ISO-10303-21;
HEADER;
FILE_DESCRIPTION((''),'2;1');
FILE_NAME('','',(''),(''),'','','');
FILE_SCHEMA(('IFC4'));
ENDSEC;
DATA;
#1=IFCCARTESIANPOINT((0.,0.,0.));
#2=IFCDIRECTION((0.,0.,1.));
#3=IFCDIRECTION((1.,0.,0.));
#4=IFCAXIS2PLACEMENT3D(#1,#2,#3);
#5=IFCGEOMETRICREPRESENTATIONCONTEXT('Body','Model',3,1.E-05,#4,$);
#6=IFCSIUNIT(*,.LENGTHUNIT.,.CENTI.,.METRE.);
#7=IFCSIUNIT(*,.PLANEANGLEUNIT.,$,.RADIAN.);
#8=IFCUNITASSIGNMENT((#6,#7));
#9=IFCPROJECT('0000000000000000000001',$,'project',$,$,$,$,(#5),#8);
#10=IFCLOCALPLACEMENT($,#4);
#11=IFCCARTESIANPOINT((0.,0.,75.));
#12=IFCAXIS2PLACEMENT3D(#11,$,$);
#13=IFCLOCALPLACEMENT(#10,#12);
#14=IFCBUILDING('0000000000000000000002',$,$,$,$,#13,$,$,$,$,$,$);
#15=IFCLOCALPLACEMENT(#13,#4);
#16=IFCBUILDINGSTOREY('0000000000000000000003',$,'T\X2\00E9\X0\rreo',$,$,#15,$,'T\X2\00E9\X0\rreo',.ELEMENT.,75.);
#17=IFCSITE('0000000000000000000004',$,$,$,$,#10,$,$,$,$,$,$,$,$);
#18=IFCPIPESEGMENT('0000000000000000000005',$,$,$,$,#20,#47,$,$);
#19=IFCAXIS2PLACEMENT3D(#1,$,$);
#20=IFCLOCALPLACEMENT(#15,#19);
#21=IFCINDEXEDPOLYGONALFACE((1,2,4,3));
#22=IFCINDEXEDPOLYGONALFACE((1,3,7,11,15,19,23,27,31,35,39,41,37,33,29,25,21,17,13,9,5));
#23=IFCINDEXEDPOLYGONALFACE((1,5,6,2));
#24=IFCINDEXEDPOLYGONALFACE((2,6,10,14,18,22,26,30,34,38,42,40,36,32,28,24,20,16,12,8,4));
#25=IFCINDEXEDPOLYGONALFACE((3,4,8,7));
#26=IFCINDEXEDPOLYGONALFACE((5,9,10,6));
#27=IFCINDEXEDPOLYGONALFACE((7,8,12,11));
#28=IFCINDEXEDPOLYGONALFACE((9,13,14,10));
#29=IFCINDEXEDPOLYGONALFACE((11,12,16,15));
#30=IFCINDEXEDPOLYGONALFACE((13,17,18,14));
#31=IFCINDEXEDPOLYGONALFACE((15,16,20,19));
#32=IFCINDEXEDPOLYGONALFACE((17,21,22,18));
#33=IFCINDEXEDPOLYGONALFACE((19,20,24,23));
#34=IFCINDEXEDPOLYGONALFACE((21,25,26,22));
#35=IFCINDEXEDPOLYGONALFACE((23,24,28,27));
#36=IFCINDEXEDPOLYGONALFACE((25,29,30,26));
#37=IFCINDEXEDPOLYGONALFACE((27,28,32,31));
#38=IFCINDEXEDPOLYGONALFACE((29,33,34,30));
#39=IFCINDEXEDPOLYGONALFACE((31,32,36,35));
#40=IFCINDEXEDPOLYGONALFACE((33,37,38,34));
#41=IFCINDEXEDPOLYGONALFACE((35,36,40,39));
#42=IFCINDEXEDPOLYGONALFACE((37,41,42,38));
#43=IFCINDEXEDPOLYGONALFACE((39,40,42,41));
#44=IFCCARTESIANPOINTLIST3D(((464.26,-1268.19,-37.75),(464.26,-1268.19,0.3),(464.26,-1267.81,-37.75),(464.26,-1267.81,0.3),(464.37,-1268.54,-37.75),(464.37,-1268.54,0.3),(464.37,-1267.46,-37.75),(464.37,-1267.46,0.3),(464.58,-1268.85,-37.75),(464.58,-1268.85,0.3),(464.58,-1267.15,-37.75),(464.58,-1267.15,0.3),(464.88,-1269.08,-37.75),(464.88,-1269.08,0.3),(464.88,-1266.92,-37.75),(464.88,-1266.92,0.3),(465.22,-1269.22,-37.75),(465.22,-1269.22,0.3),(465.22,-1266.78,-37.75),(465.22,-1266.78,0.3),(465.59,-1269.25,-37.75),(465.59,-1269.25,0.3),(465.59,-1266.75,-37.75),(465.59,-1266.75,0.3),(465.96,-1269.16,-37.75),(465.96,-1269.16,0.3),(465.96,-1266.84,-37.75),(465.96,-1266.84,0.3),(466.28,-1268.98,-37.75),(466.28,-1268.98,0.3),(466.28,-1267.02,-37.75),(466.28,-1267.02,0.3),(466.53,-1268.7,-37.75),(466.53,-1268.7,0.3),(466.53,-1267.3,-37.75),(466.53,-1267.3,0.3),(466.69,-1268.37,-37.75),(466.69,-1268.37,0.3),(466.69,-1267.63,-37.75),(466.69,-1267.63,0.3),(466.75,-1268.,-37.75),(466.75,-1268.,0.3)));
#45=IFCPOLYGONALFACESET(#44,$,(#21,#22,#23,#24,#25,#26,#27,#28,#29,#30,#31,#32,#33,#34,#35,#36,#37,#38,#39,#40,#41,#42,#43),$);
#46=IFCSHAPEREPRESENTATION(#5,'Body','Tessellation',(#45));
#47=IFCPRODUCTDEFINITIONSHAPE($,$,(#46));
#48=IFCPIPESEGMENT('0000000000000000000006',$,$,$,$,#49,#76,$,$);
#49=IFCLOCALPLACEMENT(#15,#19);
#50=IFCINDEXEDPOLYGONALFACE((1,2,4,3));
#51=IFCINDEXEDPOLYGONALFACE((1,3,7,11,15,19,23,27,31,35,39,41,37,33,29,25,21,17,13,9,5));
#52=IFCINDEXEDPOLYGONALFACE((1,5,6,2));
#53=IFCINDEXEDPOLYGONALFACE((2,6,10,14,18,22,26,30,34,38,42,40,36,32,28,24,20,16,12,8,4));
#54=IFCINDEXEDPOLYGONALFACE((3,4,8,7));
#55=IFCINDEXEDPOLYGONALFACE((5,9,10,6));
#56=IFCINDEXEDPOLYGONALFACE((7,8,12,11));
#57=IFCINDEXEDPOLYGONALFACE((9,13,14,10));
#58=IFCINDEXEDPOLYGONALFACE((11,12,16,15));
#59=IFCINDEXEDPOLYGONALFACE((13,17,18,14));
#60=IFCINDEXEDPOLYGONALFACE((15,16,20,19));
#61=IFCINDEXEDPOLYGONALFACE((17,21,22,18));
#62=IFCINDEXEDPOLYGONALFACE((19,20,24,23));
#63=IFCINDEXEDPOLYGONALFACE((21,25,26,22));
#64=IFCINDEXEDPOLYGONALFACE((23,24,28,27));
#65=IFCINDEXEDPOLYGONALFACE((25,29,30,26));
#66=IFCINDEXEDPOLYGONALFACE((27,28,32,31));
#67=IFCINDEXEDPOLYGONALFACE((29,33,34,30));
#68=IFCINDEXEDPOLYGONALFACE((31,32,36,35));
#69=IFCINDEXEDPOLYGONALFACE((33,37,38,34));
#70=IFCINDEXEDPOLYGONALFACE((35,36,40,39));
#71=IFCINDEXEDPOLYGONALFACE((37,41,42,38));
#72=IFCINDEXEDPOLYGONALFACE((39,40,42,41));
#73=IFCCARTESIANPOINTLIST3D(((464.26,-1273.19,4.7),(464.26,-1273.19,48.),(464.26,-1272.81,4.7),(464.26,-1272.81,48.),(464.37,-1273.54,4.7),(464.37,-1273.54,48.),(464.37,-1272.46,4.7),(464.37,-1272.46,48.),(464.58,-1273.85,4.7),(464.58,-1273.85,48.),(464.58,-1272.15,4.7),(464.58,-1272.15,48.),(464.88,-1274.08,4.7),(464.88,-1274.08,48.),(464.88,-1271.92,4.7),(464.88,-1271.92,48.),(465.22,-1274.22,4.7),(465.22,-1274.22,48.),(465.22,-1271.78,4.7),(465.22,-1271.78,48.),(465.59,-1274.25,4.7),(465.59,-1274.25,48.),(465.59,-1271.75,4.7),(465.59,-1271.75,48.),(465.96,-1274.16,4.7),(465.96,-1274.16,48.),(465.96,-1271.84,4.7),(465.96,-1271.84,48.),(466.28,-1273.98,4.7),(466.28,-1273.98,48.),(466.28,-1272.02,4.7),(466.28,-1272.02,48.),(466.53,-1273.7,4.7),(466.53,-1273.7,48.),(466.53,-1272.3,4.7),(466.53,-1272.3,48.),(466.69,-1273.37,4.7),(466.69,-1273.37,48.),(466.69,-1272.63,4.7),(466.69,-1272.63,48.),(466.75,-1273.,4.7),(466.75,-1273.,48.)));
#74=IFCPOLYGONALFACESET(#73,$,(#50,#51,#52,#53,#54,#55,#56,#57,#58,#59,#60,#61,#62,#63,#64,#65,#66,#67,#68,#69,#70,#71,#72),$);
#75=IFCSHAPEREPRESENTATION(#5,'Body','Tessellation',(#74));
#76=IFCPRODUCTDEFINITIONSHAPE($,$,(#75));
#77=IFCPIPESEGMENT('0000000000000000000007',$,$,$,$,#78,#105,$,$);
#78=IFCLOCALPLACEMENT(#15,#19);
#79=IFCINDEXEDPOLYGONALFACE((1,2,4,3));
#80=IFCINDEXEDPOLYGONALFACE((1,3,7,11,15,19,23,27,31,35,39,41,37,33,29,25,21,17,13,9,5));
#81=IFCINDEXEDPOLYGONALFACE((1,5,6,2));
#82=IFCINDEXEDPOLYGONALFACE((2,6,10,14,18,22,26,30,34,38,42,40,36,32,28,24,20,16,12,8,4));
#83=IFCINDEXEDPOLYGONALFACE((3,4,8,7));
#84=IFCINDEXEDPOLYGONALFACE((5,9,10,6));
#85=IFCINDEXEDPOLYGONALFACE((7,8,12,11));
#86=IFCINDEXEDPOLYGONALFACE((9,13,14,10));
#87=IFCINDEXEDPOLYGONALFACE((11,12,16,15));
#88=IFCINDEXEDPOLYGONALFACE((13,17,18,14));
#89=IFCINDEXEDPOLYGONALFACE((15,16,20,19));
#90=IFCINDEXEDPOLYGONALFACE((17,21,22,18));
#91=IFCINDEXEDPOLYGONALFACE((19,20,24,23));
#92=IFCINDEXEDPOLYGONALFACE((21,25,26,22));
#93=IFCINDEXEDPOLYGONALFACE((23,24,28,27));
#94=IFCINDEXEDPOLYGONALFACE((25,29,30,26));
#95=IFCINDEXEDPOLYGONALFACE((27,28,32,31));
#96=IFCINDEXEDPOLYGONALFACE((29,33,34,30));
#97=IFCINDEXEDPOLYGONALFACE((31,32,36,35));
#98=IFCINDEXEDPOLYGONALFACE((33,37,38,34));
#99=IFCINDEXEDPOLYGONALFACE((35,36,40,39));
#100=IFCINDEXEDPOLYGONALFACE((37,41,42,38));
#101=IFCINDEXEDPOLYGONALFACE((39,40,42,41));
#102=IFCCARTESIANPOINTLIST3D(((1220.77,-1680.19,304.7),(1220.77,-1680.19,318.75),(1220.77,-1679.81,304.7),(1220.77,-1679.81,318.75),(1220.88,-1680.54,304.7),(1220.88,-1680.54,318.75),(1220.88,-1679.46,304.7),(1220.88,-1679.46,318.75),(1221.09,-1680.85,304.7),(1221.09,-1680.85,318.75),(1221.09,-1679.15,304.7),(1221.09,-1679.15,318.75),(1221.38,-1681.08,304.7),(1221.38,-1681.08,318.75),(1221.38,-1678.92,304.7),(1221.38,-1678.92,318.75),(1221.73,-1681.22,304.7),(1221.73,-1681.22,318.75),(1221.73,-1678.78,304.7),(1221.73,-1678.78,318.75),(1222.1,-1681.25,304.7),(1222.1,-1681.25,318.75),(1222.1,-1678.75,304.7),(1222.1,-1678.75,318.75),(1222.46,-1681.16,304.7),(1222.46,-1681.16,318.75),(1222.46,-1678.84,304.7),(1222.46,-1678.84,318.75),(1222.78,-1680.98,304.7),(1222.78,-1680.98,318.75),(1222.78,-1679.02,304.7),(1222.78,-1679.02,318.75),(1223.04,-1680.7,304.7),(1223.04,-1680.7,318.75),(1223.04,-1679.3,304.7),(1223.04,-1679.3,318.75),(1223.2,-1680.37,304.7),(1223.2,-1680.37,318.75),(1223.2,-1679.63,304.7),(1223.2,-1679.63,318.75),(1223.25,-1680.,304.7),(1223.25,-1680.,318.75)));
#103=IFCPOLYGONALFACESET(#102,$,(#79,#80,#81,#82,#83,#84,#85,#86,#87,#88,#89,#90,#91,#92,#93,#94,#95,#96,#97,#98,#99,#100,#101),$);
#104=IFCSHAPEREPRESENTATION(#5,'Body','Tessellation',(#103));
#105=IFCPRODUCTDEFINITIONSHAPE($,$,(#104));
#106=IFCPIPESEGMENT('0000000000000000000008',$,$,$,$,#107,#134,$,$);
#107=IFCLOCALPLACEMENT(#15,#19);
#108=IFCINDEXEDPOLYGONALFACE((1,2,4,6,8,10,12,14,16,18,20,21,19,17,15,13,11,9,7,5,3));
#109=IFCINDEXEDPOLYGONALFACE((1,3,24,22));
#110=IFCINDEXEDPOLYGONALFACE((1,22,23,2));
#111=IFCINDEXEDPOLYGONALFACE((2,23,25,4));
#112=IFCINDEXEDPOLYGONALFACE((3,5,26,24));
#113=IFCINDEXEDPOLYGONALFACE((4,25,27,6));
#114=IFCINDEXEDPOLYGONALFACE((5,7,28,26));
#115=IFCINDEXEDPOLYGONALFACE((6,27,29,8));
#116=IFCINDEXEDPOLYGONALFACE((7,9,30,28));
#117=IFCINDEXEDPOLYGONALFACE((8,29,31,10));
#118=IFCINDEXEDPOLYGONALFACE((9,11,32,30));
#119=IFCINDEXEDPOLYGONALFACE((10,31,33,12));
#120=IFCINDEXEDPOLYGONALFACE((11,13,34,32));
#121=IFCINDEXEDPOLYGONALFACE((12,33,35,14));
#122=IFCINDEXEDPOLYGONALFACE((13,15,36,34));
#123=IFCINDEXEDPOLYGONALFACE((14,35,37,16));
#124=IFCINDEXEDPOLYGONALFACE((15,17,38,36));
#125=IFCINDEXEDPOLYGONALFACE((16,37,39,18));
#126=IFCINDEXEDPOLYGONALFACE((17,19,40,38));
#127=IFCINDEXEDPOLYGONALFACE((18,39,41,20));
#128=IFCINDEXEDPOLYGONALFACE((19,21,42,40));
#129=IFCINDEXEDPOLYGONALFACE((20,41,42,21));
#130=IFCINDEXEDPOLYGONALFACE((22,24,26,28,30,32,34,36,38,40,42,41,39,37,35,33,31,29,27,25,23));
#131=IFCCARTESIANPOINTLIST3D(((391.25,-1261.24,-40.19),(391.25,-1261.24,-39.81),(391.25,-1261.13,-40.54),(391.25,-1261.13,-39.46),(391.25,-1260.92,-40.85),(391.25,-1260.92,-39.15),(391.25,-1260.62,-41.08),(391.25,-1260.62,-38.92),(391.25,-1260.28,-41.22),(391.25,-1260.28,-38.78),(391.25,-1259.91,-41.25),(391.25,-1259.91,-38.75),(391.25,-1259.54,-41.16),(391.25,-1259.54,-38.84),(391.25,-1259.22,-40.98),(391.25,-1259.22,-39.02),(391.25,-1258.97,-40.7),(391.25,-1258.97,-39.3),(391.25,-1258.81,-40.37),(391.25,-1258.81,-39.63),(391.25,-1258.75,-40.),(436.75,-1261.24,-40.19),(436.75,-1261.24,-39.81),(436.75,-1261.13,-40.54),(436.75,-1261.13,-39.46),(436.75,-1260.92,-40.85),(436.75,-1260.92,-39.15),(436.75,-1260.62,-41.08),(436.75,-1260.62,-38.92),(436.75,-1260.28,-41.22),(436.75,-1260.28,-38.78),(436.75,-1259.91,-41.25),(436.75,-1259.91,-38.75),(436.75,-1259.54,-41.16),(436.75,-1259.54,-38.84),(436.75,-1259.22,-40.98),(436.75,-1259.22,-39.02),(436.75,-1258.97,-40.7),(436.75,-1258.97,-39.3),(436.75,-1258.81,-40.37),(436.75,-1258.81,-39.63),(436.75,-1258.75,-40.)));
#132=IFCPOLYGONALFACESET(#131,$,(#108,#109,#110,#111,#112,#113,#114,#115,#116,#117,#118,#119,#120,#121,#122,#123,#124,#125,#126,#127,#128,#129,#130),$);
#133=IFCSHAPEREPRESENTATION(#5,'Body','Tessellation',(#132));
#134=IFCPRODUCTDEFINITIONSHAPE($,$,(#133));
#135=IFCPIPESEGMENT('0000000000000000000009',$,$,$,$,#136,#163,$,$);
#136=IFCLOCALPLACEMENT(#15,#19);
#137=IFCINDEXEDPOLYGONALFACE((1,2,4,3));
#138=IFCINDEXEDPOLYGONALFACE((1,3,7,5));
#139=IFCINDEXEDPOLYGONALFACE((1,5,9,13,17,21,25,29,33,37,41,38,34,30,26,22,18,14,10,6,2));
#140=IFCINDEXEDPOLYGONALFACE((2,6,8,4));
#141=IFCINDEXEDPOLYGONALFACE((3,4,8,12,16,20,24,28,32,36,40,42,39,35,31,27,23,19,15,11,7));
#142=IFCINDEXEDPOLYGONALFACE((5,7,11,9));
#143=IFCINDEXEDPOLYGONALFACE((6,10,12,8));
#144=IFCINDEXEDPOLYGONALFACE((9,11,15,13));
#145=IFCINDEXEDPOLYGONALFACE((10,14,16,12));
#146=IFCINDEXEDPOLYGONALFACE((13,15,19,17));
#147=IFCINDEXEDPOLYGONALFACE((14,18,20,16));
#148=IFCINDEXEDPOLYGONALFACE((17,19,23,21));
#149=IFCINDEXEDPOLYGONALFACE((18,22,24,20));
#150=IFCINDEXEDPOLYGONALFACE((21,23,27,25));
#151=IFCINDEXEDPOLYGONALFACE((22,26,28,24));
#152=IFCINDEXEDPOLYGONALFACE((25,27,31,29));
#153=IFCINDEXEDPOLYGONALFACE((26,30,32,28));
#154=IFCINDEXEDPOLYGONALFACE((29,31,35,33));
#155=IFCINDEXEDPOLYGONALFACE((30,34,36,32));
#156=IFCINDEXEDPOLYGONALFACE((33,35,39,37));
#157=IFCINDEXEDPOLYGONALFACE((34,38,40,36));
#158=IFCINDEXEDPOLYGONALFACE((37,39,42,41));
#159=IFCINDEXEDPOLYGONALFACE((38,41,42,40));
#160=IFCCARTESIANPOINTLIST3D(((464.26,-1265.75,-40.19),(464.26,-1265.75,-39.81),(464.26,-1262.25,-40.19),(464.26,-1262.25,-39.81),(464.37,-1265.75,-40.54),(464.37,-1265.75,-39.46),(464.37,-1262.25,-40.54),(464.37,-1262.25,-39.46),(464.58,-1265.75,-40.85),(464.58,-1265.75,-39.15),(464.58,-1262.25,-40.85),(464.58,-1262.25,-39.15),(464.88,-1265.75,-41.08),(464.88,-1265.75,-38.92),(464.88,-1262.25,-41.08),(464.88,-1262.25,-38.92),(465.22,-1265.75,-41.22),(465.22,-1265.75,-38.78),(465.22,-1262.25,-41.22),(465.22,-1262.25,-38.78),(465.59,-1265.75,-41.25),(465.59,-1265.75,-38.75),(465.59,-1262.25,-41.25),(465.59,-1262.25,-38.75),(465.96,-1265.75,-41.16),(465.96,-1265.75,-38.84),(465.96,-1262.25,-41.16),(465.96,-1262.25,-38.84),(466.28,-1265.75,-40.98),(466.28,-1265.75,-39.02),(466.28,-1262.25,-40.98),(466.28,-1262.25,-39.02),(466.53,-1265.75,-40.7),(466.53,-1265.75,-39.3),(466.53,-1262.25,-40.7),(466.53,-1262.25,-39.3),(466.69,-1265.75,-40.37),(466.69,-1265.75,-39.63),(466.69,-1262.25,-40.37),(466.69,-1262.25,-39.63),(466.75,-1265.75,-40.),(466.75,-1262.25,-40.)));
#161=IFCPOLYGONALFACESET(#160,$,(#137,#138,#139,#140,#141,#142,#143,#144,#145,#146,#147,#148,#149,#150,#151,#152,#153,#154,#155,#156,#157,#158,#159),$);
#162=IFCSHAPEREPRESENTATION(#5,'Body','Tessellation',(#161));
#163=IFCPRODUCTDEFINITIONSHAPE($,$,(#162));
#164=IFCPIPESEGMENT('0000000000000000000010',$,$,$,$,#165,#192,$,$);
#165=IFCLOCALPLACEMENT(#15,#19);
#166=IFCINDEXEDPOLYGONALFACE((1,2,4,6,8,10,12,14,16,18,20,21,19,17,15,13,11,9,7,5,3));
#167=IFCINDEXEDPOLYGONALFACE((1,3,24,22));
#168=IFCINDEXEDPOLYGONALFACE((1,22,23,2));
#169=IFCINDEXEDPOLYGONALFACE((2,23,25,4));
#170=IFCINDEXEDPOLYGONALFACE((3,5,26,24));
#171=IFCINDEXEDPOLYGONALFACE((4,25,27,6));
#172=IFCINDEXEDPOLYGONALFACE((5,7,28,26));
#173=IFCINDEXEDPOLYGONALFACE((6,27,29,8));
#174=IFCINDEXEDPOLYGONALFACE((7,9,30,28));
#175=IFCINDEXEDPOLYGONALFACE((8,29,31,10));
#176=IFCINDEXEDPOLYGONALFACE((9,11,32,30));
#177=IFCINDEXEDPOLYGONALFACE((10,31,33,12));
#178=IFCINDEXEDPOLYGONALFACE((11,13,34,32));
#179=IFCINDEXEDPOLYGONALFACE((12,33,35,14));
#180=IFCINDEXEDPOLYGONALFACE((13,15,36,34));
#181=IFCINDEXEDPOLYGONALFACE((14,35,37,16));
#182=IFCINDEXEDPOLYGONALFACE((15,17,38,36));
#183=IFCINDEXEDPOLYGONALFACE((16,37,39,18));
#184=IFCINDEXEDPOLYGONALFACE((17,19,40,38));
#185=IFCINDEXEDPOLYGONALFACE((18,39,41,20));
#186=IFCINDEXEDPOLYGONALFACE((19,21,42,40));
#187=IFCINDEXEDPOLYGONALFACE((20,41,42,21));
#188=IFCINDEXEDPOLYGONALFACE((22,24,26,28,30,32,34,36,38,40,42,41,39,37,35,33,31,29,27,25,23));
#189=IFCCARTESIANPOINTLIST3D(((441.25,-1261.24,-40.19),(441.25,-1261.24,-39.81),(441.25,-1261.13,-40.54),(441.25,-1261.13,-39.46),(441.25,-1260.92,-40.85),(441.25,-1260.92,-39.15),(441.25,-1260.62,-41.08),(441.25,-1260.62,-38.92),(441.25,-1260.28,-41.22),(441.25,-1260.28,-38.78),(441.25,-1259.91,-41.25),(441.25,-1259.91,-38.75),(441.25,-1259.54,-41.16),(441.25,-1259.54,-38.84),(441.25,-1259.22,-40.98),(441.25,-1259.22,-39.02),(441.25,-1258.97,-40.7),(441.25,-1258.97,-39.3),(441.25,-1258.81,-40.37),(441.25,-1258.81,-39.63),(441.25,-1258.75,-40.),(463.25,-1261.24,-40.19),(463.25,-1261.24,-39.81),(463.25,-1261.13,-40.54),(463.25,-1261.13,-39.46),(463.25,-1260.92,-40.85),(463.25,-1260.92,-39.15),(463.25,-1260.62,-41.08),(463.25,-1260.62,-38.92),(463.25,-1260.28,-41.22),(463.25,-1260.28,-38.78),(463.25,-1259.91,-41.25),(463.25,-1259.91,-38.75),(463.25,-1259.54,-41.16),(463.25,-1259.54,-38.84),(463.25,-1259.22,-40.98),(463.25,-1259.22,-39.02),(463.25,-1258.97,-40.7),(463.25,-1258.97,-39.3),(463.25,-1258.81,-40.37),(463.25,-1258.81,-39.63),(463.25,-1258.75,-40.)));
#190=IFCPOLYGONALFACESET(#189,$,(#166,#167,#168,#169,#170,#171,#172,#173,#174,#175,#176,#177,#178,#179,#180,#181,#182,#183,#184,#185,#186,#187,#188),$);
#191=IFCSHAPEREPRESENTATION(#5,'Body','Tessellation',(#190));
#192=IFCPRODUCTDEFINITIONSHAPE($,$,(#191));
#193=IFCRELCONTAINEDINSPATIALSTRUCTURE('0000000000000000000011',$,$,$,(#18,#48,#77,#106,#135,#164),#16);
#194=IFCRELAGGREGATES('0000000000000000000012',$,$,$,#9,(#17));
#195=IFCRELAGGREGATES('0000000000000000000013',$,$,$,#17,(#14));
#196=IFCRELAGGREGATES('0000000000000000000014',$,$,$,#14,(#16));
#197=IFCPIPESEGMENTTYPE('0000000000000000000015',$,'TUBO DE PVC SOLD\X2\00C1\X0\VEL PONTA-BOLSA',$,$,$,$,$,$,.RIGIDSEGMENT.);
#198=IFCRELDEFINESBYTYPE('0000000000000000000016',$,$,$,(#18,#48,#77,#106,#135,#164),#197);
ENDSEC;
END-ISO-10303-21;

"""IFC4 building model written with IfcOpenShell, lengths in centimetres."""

from ifc_helpers import new_model, si_unit, frame, origin_with_axes, origin_2d_with_axis, place, context, project, spatial, circle, extrude, type_object, element, save


model = new_model("IFC4")

# Units and contexts
model_context = context("Model", 3, precision=1e-05, world=origin_with_axes(), identifier="Body")
ifc_project = project(units=[si_unit("LENGTHUNIT", "METRE", prefix="CENTI"), si_unit("PLANEANGLEUNIT", "RADIAN")], contexts=[model_context])

# Site, building, storey
site_placement = place(None, origin_with_axes())
site = spatial("IfcSite", under=ifc_project, at=site_placement)
building_placement = place(site_placement, frame((0.0, 0.0, 75.0)))
building = spatial("IfcBuilding", under=site, at=building_placement)
storey_placement = place(building_placement, origin_with_axes())
storey = spatial("IfcBuildingStorey", under=building, at=storey_placement, Name="Térreo", LongName="Térreo", CompositionType="ELEMENT", Elevation=75.0)

# Pipe segments
pipe_segment_type_1 = type_object("IfcPipeSegmentType", Name="TUBO DE PVC SOLDÁVEL PONTA-BOLSA", PredefinedType="RIGIDSEGMENT")
pipe_segment_1_placement = place(storey_placement, frame((465.5, -1268.0, 0.3), z_axis=(0.0, 0.0, 1.0), x_axis=(1.0, 0.0, 0.0)))
element("IfcPipeSegment", 1, at=pipe_segment_1_placement, inside=storey, type_object=pipe_segment_type_1, context=model_context, shape_type="SolidModel", body=[
    extrude(circle(Radius=1.25, at=origin_2d_with_axis()), frame((0.0, 0.0, -38.05), z_axis=(0.0, 0.0, 1.0), x_axis=(1.0, 0.0, 0.0)), (0.0, 0.0, 1.0), 38.05),
])
pipe_segment_2_placement = place(storey_placement, frame((465.5, -1273.0, 48.0), z_axis=(0.0, 0.0, 1.0), x_axis=(1.0, 0.0, 0.0)))
element("IfcPipeSegment", 2, at=pipe_segment_2_placement, inside=storey, type_object=pipe_segment_type_1, context=model_context, shape_type="SolidModel", body=[
    extrude(circle(Radius=1.25, at=origin_2d_with_axis()), frame((0.0, 0.0, -43.3), z_axis=(0.0, 0.0, 1.0), x_axis=(1.0, 0.0, 0.0)), (0.0, 0.0, 1.0), 43.3),
])
pipe_segment_3_placement = place(storey_placement, frame((1222.0, -1680.0, 318.75), z_axis=(0.0, 0.0, 1.0), x_axis=(1.0, 0.0, 0.0)))
element("IfcPipeSegment", 3, at=pipe_segment_3_placement, inside=storey, type_object=pipe_segment_type_1, context=model_context, shape_type="SolidModel", body=[
    extrude(circle(Radius=1.25, at=origin_2d_with_axis()), frame((0.0, 0.0, 0.0), z_axis=(0.0, 0.0, -1.0), x_axis=(1.0, 0.0, 0.0)), (0.0, 0.0, 1.0), 14.05),
])
pipe_segment_4_placement = place(storey_placement, frame((414.0, -1260.0, -38.75), z_axis=(0.0, 0.0, 1.0), x_axis=(1.0, 0.0, 0.0)))
element("IfcPipeSegment", 4, at=pipe_segment_4_placement, inside=storey, type_object=pipe_segment_type_1, context=model_context, shape_type="SolidModel", body=[
    extrude(circle(Radius=1.25, at=origin_2d_with_axis()), frame((-22.75, 0.0, -1.25), z_axis=(1.0, 0.0, 0.0), x_axis=(0.0, 1.0, 0.0)), (0.0, 0.0, 1.0), 45.5),
])
pipe_segment_5_placement = place(storey_placement, frame((465.5, -1264.0, -38.75), z_axis=(0.0, 0.0, 1.0), x_axis=(1.0, 0.0, 0.0)))
element("IfcPipeSegment", 5, at=pipe_segment_5_placement, inside=storey, type_object=pipe_segment_type_1, context=model_context, shape_type="SolidModel", body=[
    extrude(circle(Radius=1.25, at=origin_2d_with_axis()), frame((0.0, 1.75, -1.25), z_axis=(0.0, -1.0, 0.0), x_axis=(1.0, 0.0, 0.0)), (0.0, 0.0, 1.0), 3.5),
])
pipe_segment_6_placement = place(storey_placement, frame((452.25, -1260.0, -38.75), z_axis=(0.0, 0.0, 1.0), x_axis=(1.0, 0.0, 0.0)))
element("IfcPipeSegment", 6, at=pipe_segment_6_placement, inside=storey, type_object=pipe_segment_type_1, context=model_context, shape_type="SolidModel", body=[
    extrude(circle(Radius=1.25, at=origin_2d_with_axis()), frame((-11.0, 0.0, -1.25), z_axis=(1.0, 0.0, 0.0), x_axis=(0.0, 1.0, 0.0)), (0.0, 0.0, 1.0), 22.0),
])

save(model, "model.ifc")
